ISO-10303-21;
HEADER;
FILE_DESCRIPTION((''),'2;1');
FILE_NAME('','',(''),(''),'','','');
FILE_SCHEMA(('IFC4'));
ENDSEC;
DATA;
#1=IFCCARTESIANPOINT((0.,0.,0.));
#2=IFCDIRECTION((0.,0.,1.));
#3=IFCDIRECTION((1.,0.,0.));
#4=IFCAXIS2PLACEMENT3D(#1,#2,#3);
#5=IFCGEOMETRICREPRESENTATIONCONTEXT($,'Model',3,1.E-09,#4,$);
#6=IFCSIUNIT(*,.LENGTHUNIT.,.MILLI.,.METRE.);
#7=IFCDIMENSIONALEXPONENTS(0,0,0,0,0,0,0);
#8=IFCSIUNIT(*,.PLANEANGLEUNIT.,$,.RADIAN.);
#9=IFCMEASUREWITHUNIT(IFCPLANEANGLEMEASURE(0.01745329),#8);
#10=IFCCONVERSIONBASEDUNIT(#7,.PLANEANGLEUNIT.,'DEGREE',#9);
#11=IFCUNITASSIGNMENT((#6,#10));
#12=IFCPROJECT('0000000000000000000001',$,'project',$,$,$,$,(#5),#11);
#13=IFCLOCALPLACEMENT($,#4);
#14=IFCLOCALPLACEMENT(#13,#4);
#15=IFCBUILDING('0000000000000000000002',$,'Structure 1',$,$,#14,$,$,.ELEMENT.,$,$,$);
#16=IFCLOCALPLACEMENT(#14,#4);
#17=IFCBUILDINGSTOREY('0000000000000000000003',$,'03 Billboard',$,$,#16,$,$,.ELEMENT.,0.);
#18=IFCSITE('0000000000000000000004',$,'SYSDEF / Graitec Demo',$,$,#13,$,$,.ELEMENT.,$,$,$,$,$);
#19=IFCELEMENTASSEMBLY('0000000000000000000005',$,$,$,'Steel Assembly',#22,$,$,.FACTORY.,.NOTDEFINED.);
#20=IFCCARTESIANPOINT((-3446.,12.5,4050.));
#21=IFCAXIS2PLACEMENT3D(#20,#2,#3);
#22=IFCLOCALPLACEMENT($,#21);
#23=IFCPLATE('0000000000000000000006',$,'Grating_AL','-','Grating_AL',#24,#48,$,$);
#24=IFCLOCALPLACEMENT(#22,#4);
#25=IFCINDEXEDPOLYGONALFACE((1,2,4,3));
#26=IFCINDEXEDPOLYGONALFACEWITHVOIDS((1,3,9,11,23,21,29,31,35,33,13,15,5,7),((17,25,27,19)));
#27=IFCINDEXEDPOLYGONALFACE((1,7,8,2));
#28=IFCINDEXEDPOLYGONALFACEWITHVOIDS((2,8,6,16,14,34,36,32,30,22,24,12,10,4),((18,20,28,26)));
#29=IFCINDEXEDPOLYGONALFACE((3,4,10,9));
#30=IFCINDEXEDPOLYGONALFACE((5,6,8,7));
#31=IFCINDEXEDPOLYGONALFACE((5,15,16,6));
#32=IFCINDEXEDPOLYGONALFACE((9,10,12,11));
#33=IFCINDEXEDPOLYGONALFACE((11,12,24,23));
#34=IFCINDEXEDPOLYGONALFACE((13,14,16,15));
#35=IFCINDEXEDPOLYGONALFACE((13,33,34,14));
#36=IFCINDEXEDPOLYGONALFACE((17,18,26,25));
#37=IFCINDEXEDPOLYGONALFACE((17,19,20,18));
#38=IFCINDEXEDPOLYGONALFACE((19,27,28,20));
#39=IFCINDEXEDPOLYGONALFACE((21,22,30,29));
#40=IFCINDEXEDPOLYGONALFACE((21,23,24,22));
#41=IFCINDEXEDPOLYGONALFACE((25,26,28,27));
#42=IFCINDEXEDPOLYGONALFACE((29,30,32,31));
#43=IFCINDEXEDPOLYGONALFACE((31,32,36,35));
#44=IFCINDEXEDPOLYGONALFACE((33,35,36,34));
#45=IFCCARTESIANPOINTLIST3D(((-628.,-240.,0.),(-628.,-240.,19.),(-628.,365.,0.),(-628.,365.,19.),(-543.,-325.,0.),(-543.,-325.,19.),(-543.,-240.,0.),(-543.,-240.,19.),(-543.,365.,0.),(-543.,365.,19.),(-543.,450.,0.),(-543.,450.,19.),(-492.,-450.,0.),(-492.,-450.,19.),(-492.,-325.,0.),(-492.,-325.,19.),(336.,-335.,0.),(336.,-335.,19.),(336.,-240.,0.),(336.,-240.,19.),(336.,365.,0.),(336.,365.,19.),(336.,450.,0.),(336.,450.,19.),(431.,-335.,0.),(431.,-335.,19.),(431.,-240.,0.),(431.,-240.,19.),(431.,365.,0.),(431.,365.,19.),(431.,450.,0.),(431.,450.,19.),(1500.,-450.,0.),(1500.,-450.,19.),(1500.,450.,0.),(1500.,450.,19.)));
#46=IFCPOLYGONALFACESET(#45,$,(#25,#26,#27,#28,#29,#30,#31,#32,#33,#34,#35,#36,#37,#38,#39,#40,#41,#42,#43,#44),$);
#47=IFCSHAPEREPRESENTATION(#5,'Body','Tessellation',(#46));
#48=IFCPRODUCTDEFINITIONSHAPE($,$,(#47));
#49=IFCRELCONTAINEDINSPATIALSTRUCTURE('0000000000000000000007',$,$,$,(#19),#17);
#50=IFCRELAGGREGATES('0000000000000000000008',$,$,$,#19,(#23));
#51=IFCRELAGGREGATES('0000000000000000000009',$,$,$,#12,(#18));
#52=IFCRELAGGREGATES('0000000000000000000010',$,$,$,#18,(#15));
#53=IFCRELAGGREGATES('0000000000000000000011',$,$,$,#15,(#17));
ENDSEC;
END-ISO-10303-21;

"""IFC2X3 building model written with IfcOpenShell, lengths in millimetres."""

from ifc_helpers import new_model, entity, si_unit, converted_unit, frame, origin, origin_with_axes, place, context, project, spatial, polyline, outline, extrude, element, aggregate, save


model = new_model("IFC2X3")

# Units and contexts
model_context = context("Model", 3, precision=1e-09, world=origin_with_axes())
ifc_project = project(units=[si_unit("LENGTHUNIT", "METRE", prefix="MILLI"), converted_unit("PLANEANGLEUNIT", "DEGREE", entity("IfcPlaneAngleMeasure", 0.01745329), si_unit("PLANEANGLEUNIT", "RADIAN"), dimensions=[0, 0, 0, 0, 0, 0, 0])], contexts=[model_context])

# Site, building, storey
site_placement = place(None, origin_with_axes())
site = spatial("IfcSite", under=ifc_project, at=site_placement, Name="SYSDEF / Graitec Demo", CompositionType="ELEMENT")
building_placement = place(site_placement, origin_with_axes())
building = spatial("IfcBuilding", under=site, at=building_placement, Name="Structure 1", CompositionType="ELEMENT")
storey_placement = place(building_placement, origin_with_axes())
storey = spatial("IfcBuildingStorey", under=building, at=storey_placement, Name="03 Billboard", CompositionType="ELEMENT", Elevation=0.0)

# Element assembly, plate, openings
assembly_1_placement = place(None, frame((-3446.0, 12.5, 4050.0), z_axis=(0.0, 0.0, 1.0), x_axis=(1.0, 0.0, 0.0)))
assembly_1 = element("IfcElementAssembly", 1, at=assembly_1_placement, inside=storey, ObjectType="Steel Assembly", AssemblyPlace="FACTORY", PredefinedType="NOTDEFINED")
plate_placement = place(assembly_1_placement, origin_with_axes())
plate = element("IfcPlate", 2, at=plate_placement, Name="Grating_AL", Description="-", ObjectType="Grating_AL", context=model_context, shape_type="SweptSolid", body=[
    extrude(outline(polyline([(-1500.0, -450.0), (1500.0, -450.0), (1500.0, 450.0), (-1500.0, 450.0), (-1500.0, -450.0)])), origin_with_axes(), (0.0, 0.0, 1.0), 19.0),
])
opening_1_placement = place(plate_placement, frame((0.0, 0.0, -0.1), z_axis=(0.0, 0.0, 1.0), x_axis=(1.0, 0.0, 0.0)))
element("IfcOpeningElement", 3, at=opening_1_placement, cuts=plate, ObjectType="Opening", context=model_context, shape_type="SweptSolid", body=[
    extrude(outline(polyline([(-1500.0, -450.0), (-628.0, -450.0), (-628.0, 450.0), (-1500.0, 450.0), (-1500.0, -450.0)])), origin(), (0.0, 0.0, 1.0), 19.2),
])
opening_2_placement = place(plate_placement, frame((0.0, 0.0, -0.1), z_axis=(0.0, 0.0, 1.0), x_axis=(1.0, 0.0, 0.0)))
element("IfcOpeningElement", 4, at=opening_2_placement, cuts=plate, ObjectType="Opening", context=model_context, shape_type="SweptSolid", body=[
    extrude(outline(polyline([(-638.0, 365.0), (-543.0, 365.0), (-543.0, 460.0), (-638.0, 460.0), (-638.0, 365.0)])), origin(), (0.0, 0.0, 1.0), 19.2),
])
opening_3_placement = place(plate_placement, frame((0.0, 0.0, -0.1), z_axis=(0.0, 0.0, 1.0), x_axis=(1.0, 0.0, 0.0)))
element("IfcOpeningElement", 5, at=opening_3_placement, cuts=plate, ObjectType="Opening", context=model_context, shape_type="SweptSolid", body=[
    extrude(outline(polyline([(-638.0, -335.0), (-543.0, -335.0), (-543.0, -240.0), (-638.0, -240.0), (-638.0, -335.0)])), origin(), (0.0, 0.0, 1.0), 19.2),
])
opening_4_placement = place(plate_placement, frame((0.0, 0.0, -0.1), z_axis=(0.0, 0.0, 1.0), x_axis=(1.0, 0.0, 0.0)))
element("IfcOpeningElement", 6, at=opening_4_placement, cuts=plate, ObjectType="Opening", context=model_context, shape_type="SweptSolid", body=[
    extrude(outline(polyline([(336.0, 365.0), (431.0, 365.0), (431.0, 460.0), (336.0, 460.0), (336.0, 365.0)])), origin(), (0.0, 0.0, 1.0), 19.2),
])
opening_5_placement = place(plate_placement, frame((0.0, 0.0, -0.1), z_axis=(0.0, 0.0, 1.0), x_axis=(1.0, 0.0, 0.0)))
element("IfcOpeningElement", 7, at=opening_5_placement, cuts=plate, ObjectType="Opening", context=model_context, shape_type="SweptSolid", body=[
    extrude(outline(polyline([(336.0, -335.0), (431.0, -335.0), (431.0, -240.0), (336.0, -240.0), (336.0, -335.0)])), origin(), (0.0, 0.0, 1.0), 19.2),
])
opening_6_placement = place(plate_placement, frame((0.0, 0.0, -0.1), z_axis=(0.0, 0.0, 1.0), x_axis=(1.0, 0.0, 0.0)))
element("IfcOpeningElement", 8, at=opening_6_placement, cuts=plate, ObjectType="Opening", context=model_context, shape_type="SweptSolid", body=[
    extrude(outline(polyline([(-638.0, -485.0), (-492.0, -485.0), (-492.0, -325.0), (-638.0, -325.0), (-638.0, -485.0)])), origin(), (0.0, 0.0, 1.0), 19.2),
])
aggregate(assembly_1, [plate])

save(model, "model.ifc")
